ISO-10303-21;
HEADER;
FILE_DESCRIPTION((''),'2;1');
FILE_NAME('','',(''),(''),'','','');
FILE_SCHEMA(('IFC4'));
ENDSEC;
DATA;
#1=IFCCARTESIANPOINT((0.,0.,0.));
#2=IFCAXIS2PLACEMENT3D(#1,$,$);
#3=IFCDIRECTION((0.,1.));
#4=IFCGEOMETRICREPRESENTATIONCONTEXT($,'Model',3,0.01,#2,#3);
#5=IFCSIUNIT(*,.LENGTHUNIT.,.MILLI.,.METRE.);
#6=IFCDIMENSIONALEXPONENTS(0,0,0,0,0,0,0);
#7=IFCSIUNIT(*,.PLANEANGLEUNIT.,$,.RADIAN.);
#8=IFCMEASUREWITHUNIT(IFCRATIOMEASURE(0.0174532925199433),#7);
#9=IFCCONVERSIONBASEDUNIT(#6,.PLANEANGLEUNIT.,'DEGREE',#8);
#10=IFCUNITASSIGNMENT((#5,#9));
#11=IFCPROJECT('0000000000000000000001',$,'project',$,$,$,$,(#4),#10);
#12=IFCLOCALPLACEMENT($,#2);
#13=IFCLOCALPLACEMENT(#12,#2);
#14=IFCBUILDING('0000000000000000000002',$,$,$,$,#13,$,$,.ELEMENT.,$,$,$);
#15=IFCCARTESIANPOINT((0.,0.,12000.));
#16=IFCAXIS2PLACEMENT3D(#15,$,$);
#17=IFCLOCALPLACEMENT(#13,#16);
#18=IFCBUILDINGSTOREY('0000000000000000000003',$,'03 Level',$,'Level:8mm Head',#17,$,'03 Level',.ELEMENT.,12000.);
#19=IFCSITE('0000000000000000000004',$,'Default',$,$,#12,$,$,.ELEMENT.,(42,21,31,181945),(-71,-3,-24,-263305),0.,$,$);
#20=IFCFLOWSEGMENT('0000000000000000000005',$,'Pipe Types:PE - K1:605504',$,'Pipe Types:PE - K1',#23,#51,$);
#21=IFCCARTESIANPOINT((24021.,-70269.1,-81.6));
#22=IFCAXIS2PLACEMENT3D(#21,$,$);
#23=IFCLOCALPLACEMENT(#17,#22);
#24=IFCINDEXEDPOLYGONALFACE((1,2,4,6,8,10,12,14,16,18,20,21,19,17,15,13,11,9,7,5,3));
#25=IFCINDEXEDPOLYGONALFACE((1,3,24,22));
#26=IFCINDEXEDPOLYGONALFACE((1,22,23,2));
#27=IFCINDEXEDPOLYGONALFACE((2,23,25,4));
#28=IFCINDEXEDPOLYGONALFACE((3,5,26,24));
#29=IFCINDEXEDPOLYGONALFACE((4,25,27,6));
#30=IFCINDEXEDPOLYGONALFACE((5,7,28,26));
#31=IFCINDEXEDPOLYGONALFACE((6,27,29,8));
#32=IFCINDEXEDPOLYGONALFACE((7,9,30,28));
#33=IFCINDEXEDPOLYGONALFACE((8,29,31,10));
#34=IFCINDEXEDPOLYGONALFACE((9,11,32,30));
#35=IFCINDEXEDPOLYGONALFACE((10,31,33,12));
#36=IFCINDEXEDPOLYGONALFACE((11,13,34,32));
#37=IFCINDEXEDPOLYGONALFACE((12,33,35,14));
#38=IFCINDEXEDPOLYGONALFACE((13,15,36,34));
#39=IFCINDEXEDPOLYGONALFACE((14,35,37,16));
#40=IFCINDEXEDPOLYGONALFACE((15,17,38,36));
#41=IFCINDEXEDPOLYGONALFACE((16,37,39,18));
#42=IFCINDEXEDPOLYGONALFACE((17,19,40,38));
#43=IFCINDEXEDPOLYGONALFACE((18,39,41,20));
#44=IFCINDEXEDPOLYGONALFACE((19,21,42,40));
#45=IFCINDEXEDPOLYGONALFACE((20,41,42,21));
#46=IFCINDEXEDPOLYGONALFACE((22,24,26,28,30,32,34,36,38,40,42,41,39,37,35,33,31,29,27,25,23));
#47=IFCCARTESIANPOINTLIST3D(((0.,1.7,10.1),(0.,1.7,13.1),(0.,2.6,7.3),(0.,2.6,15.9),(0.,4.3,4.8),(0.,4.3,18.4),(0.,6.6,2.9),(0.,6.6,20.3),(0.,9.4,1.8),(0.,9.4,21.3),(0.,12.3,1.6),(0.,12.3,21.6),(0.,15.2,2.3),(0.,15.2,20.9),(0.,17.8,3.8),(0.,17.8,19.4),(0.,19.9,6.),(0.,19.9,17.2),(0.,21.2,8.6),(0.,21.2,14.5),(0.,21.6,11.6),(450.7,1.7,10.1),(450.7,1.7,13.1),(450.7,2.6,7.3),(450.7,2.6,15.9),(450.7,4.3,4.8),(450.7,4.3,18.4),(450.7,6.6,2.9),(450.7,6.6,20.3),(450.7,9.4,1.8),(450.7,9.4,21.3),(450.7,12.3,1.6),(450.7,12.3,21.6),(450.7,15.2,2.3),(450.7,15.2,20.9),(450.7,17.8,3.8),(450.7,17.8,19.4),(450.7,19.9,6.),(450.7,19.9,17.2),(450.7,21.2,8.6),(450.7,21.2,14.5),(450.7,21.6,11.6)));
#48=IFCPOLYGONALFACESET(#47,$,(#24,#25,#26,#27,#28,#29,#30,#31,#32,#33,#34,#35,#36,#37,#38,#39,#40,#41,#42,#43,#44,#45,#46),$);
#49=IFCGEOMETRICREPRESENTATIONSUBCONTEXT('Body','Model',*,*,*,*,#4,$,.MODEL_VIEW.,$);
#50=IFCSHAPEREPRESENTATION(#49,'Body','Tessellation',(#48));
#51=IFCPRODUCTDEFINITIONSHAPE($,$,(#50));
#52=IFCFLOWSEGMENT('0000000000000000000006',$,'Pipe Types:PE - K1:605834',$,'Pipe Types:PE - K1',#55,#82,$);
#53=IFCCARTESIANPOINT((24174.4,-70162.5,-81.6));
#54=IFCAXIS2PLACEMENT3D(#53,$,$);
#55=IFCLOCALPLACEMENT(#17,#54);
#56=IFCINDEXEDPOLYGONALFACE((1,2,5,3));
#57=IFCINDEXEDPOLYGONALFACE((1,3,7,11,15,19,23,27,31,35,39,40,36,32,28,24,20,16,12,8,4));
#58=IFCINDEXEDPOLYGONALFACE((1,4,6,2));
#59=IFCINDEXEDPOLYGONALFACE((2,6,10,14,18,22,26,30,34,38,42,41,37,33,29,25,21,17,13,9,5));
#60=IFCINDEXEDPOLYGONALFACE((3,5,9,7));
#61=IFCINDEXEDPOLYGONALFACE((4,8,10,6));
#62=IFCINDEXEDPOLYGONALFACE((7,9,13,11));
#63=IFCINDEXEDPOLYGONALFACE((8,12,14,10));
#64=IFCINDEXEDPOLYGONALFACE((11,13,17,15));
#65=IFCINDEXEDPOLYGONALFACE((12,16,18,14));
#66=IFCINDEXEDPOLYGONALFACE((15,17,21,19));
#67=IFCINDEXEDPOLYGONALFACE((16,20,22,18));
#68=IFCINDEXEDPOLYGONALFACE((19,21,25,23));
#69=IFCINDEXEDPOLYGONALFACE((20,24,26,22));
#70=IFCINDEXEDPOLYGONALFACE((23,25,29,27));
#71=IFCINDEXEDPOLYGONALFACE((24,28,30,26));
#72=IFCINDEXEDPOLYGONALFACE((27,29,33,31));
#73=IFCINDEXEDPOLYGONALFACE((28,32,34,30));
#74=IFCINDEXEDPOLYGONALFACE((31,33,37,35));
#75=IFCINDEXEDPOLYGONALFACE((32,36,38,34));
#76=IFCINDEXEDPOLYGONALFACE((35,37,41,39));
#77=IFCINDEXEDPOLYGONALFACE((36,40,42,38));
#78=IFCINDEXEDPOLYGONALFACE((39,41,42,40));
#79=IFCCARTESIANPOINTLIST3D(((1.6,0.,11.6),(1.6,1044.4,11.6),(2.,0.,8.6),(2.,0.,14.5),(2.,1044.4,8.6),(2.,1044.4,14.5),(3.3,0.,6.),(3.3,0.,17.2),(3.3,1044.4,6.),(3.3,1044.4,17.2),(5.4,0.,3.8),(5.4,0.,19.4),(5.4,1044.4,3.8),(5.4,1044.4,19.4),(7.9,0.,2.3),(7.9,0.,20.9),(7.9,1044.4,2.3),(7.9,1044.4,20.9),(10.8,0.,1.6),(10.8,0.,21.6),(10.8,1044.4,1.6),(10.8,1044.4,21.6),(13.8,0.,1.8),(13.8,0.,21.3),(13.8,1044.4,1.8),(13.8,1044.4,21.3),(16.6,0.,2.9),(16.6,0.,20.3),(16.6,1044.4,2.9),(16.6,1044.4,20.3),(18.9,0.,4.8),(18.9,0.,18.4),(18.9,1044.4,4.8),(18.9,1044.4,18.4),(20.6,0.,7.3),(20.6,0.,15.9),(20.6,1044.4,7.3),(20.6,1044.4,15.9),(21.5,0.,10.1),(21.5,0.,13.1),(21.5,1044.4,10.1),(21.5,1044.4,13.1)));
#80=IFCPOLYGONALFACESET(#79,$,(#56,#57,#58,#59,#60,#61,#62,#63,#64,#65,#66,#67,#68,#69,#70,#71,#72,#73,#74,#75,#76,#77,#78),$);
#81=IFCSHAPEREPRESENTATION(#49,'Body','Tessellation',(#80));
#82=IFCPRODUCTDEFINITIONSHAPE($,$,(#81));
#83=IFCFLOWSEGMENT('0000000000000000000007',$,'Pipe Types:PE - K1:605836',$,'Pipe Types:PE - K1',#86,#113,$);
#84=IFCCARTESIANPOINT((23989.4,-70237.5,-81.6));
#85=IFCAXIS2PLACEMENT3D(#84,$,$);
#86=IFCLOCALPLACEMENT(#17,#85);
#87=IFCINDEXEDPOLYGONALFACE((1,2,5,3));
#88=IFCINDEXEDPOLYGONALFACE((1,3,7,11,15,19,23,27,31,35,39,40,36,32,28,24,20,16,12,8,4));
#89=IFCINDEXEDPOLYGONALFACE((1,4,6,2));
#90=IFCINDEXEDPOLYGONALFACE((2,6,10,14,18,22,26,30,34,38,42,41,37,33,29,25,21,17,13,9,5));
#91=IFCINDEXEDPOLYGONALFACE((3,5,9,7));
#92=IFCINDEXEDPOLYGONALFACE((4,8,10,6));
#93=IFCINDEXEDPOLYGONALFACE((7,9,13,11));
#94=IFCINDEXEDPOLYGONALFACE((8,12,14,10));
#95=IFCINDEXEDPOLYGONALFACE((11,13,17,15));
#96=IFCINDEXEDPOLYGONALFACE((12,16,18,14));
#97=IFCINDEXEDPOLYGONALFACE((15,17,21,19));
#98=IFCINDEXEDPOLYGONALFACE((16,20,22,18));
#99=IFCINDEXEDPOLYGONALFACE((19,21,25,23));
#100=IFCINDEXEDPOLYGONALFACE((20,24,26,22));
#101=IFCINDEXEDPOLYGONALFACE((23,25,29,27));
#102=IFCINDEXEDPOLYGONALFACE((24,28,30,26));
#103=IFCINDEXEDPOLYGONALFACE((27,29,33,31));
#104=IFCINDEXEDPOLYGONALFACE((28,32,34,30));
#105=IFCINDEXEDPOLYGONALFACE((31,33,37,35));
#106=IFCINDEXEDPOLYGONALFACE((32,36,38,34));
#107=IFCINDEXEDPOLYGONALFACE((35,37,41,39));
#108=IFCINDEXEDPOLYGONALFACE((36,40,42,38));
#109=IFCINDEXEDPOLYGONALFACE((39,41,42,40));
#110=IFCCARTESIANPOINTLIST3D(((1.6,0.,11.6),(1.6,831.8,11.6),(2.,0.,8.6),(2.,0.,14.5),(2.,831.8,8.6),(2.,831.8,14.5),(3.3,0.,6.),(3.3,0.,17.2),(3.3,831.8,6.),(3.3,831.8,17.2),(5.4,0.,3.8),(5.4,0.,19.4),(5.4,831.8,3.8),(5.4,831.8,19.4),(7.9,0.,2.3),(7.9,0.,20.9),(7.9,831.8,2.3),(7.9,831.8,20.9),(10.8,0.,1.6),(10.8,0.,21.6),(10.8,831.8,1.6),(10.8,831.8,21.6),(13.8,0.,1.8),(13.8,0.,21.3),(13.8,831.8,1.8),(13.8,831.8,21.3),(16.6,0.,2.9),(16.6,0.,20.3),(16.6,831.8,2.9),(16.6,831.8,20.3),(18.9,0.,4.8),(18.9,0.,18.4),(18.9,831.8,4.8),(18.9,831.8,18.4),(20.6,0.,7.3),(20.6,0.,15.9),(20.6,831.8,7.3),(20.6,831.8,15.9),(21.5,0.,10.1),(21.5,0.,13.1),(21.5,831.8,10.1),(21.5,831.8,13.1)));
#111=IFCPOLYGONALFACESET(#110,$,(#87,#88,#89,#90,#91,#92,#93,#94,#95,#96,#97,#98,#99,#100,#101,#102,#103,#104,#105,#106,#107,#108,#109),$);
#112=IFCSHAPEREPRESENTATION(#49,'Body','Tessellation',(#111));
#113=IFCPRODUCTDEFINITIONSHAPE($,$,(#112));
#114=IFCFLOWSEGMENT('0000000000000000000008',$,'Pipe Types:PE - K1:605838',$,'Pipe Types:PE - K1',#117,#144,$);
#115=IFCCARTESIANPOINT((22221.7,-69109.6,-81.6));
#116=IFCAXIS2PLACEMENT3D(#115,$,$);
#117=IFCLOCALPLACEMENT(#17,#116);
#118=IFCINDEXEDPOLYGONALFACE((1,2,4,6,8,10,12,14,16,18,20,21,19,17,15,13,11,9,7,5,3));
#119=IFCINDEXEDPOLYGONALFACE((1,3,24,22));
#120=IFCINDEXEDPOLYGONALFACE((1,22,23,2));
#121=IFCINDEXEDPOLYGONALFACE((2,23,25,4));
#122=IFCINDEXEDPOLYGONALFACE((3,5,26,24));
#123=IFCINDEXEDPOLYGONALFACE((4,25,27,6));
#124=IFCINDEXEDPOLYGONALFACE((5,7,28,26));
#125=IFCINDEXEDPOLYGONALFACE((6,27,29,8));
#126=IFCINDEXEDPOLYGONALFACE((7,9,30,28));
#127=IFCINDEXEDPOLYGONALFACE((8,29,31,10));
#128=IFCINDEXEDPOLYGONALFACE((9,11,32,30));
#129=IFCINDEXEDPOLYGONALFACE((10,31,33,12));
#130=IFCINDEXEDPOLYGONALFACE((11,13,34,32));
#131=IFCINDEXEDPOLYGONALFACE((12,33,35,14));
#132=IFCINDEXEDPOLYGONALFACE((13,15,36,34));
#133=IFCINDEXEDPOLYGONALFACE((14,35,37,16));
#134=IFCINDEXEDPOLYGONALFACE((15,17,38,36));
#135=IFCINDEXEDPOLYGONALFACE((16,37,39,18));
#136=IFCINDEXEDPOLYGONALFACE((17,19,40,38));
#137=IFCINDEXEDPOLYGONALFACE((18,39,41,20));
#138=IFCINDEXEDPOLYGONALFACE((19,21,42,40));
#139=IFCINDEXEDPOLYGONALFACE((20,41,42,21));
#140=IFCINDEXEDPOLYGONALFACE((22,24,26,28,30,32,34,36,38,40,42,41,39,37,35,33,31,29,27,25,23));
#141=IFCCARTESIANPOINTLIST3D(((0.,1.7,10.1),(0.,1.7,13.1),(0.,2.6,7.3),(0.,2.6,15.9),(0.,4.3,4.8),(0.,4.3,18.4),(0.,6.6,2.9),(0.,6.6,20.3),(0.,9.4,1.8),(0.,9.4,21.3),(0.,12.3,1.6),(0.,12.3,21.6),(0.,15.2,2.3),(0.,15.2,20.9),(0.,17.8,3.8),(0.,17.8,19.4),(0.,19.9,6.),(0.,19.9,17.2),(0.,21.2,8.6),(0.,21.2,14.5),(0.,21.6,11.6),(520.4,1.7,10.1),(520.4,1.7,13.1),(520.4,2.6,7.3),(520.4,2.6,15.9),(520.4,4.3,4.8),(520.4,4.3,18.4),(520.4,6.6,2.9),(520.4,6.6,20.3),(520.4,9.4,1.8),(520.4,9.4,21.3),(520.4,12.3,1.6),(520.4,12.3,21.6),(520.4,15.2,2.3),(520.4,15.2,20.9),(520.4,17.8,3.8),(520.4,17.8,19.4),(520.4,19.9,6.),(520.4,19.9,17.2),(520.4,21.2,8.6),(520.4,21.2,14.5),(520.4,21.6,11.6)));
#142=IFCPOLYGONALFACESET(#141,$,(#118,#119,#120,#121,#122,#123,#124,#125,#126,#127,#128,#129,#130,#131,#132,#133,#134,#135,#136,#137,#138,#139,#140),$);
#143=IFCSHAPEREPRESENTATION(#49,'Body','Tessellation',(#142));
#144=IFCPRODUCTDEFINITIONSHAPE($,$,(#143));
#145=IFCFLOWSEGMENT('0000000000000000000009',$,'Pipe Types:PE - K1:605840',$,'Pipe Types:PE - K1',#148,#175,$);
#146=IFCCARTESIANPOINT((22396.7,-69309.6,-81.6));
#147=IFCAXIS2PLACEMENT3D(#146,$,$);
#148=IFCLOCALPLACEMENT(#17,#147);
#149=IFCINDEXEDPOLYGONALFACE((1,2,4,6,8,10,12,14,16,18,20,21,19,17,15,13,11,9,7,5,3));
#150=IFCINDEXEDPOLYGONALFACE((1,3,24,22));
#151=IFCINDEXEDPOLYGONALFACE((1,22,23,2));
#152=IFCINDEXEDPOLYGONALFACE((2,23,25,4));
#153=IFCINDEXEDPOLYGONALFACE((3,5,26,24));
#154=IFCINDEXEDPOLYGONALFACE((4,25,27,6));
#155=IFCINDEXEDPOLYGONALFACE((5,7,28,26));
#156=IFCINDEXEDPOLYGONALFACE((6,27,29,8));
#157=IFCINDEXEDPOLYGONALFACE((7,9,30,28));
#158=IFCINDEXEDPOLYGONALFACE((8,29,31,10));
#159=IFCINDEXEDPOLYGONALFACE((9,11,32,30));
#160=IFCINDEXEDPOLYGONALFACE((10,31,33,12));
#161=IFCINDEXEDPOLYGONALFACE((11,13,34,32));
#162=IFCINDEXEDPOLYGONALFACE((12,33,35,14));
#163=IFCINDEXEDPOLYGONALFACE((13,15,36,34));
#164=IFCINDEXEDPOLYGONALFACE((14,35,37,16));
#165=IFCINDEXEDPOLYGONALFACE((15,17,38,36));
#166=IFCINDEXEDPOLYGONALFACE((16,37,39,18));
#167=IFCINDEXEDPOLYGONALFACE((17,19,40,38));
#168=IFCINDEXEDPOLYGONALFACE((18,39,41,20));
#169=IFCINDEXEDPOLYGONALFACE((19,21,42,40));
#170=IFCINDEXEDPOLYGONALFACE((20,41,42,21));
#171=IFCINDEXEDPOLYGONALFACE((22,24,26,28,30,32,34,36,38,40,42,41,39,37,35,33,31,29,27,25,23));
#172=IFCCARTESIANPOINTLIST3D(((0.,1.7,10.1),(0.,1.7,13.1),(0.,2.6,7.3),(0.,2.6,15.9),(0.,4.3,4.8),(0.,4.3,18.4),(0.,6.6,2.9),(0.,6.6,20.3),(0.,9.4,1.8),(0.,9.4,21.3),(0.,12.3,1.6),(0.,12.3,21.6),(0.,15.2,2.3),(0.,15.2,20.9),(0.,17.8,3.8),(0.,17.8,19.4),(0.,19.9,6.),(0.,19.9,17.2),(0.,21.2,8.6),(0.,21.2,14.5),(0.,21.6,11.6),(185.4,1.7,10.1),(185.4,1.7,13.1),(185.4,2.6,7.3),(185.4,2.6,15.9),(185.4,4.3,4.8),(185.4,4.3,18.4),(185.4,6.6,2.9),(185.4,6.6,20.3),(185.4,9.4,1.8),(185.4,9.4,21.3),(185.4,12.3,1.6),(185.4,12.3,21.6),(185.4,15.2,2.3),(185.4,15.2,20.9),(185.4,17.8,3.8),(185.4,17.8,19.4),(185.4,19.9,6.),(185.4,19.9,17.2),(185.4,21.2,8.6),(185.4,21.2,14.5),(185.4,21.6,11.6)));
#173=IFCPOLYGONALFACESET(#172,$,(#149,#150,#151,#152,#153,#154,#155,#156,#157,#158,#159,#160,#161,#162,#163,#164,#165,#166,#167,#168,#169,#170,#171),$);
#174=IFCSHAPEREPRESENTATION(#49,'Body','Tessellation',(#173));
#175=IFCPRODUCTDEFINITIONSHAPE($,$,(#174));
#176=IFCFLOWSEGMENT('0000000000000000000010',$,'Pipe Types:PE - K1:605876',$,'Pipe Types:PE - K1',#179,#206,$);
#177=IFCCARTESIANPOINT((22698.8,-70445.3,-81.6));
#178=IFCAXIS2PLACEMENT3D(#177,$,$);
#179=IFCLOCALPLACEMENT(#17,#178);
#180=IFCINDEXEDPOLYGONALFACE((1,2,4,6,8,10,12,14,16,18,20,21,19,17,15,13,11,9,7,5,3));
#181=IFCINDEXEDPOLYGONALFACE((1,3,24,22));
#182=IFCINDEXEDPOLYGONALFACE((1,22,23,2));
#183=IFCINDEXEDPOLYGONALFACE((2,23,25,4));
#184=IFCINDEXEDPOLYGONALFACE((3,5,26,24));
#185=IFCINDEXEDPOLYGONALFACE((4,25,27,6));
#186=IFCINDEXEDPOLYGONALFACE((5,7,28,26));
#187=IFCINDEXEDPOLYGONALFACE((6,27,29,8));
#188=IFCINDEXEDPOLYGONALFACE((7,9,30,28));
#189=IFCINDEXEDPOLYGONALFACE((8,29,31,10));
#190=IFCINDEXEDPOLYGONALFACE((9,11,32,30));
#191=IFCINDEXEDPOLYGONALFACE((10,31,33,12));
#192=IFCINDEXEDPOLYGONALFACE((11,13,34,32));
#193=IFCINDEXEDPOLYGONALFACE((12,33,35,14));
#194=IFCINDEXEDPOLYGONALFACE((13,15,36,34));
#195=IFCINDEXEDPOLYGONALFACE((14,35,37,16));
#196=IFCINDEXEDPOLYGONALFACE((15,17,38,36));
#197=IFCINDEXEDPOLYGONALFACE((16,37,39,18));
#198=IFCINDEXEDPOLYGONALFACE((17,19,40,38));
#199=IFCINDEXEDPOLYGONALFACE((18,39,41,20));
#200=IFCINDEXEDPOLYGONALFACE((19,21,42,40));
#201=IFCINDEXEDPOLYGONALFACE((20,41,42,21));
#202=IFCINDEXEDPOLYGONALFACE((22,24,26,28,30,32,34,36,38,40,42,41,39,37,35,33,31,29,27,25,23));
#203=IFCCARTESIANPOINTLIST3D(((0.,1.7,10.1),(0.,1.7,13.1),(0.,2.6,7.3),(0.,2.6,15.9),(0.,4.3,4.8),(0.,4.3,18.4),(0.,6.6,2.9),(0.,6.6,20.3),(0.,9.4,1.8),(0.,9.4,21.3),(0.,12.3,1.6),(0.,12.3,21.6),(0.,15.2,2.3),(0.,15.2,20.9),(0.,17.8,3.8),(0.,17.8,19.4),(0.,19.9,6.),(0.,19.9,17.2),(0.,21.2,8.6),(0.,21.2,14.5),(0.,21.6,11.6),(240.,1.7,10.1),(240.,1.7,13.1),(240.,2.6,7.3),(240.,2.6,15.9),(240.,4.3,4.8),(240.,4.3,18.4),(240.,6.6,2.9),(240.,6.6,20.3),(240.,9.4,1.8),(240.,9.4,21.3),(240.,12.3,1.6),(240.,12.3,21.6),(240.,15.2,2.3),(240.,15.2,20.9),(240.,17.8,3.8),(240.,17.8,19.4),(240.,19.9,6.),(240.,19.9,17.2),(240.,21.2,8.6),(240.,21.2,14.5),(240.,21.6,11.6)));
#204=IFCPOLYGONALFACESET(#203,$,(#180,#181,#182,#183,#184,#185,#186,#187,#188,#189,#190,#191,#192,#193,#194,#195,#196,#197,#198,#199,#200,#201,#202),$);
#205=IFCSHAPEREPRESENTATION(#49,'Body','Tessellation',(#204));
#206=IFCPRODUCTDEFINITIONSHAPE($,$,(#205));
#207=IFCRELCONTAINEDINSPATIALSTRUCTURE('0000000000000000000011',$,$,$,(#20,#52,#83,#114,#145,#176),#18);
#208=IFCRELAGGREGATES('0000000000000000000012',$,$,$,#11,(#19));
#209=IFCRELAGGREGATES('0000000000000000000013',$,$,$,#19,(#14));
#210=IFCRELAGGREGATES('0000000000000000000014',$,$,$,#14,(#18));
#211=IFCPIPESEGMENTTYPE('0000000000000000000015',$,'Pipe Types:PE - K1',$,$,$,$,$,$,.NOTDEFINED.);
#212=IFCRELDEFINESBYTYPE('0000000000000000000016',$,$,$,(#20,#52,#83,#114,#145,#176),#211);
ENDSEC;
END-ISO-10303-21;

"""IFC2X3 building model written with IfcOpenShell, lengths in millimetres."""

from ifc_helpers import new_model, entity, si_unit, converted_unit, direction, frame, frame_2d, origin, origin_2d_with_axis, place, context, subcontext, project, spatial, circle, extrude, type_object, element, save


model = new_model("IFC2X3")

# Units and contexts
model_context = context("Model", 3, precision=0.01, world=origin(), true_north=direction((0.0, 1.0)))
body_context = subcontext(model_context, "Body", "Model", "MODEL_VIEW")
ifc_project = project(units=[si_unit("LENGTHUNIT", "METRE", prefix="MILLI"), converted_unit("PLANEANGLEUNIT", "DEGREE", entity("IfcRatioMeasure", 0.0174532925199433), si_unit("PLANEANGLEUNIT", "RADIAN"), dimensions=[0, 0, 0, 0, 0, 0, 0])], contexts=[model_context])

# Site, building, storey
site_placement = place(None, origin())
site = spatial("IfcSite", under=ifc_project, at=site_placement, Name="Default", CompositionType="ELEMENT", RefLatitude=(42, 21, 31, 181945), RefLongitude=(-71, -3, -24, -263305), RefElevation=0.0)
building_placement = place(site_placement, origin())
building = spatial("IfcBuilding", under=site, at=building_placement, CompositionType="ELEMENT")
storey_placement = place(building_placement, frame((0.0, 0.0, 12000.0)))
storey = spatial("IfcBuildingStorey", under=building, at=storey_placement, Name="03 Level", ObjectType="Level:8mm Head", LongName="03 Level", CompositionType="ELEMENT", Elevation=12000.0)

# Flow segments
pipe_segment_type = type_object("IfcPipeSegmentType", Name="Pipe Types:PE - K1", PredefinedType="NOTDEFINED")
flow_segment_1_placement = place(storey_placement, frame((24021.0, -70269.1, -81.6)))
element("IfcFlowSegment", 1, at=flow_segment_1_placement, inside=storey, type_object=pipe_segment_type, Name="Pipe Types:PE - K1:605504", ObjectType="Pipe Types:PE - K1", context=body_context, shape_type="SweptSolid", body=[
    extrude(circle(Radius=10.0, at=frame_2d((0.0, 0.0), x_axis=(1.0, 0.0))), frame((0.0, 11.6, 11.6), z_axis=(1.0, 0.0, 0.0), x_axis=(0.0, 1.0, 0.0)), (0.0, 0.0, 1.0), 450.7),
])
flow_segment_2_placement = place(storey_placement, frame((24174.4, -70162.5, -81.6)))
element("IfcFlowSegment", 2, at=flow_segment_2_placement, inside=storey, type_object=pipe_segment_type, Name="Pipe Types:PE - K1:605834", ObjectType="Pipe Types:PE - K1", context=body_context, shape_type="SweptSolid", body=[
    extrude(circle(Radius=10.0, at=frame_2d((0.0, 0.0), x_axis=(1.0, 0.0))), frame((11.6, 0.0, 11.6), z_axis=(0.0, 1.0, 0.0), x_axis=(-1.0, 0.0, 0.0)), (0.0, 0.0, 1.0), 1044.4),
])
flow_segment_3_placement = place(storey_placement, frame((23989.4, -70237.5, -81.6)))
element("IfcFlowSegment", 3, at=flow_segment_3_placement, inside=storey, type_object=pipe_segment_type, Name="Pipe Types:PE - K1:605836", ObjectType="Pipe Types:PE - K1", context=body_context, shape_type="SweptSolid", body=[
    extrude(circle(Radius=10.0, at=frame_2d((0.0, 0.0), x_axis=(1.0, 0.0))), frame((11.6, 0.0, 11.6), z_axis=(0.0, 1.0, 0.0), x_axis=(-1.0, 0.0, 0.0)), (0.0, 0.0, 1.0), 831.8),
])
flow_segment_4_placement = place(storey_placement, frame((22221.7, -69109.6, -81.6)))
element("IfcFlowSegment", 4, at=flow_segment_4_placement, inside=storey, type_object=pipe_segment_type, Name="Pipe Types:PE - K1:605838", ObjectType="Pipe Types:PE - K1", context=body_context, shape_type="SweptSolid", body=[
    extrude(circle(Radius=10.0, at=frame_2d((0.0, 0.0), x_axis=(1.0, 0.0))), frame((0.0, 11.6, 11.6), z_axis=(1.0, 0.0, 0.0), x_axis=(0.0, 1.0, 0.0)), (0.0, 0.0, 1.0), 520.4),
])
flow_segment_5_placement = place(storey_placement, frame((22396.7, -69309.6, -81.6)))
element("IfcFlowSegment", 5, at=flow_segment_5_placement, inside=storey, type_object=pipe_segment_type, Name="Pipe Types:PE - K1:605840", ObjectType="Pipe Types:PE - K1", context=body_context, shape_type="SweptSolid", body=[
    extrude(circle(Radius=10.0, at=origin_2d_with_axis()), frame((0.0, 11.6, 11.6), z_axis=(1.0, 0.0, 0.0), x_axis=(0.0, 1.0, 0.0)), (0.0, 0.0, 1.0), 185.4),
])
flow_segment_6_placement = place(storey_placement, frame((22698.8, -70445.3, -81.6)))
element("IfcFlowSegment", 6, at=flow_segment_6_placement, inside=storey, type_object=pipe_segment_type, Name="Pipe Types:PE - K1:605876", ObjectType="Pipe Types:PE - K1", context=body_context, shape_type="SweptSolid", body=[
    extrude(circle(Radius=10.0, at=origin_2d_with_axis()), frame((0.0, 11.6, 11.6), z_axis=(1.0, 0.0, 0.0), x_axis=(0.0, 1.0, 0.0)), (0.0, 0.0, 1.0), 240.0),
])

save(model, "model.ifc")
